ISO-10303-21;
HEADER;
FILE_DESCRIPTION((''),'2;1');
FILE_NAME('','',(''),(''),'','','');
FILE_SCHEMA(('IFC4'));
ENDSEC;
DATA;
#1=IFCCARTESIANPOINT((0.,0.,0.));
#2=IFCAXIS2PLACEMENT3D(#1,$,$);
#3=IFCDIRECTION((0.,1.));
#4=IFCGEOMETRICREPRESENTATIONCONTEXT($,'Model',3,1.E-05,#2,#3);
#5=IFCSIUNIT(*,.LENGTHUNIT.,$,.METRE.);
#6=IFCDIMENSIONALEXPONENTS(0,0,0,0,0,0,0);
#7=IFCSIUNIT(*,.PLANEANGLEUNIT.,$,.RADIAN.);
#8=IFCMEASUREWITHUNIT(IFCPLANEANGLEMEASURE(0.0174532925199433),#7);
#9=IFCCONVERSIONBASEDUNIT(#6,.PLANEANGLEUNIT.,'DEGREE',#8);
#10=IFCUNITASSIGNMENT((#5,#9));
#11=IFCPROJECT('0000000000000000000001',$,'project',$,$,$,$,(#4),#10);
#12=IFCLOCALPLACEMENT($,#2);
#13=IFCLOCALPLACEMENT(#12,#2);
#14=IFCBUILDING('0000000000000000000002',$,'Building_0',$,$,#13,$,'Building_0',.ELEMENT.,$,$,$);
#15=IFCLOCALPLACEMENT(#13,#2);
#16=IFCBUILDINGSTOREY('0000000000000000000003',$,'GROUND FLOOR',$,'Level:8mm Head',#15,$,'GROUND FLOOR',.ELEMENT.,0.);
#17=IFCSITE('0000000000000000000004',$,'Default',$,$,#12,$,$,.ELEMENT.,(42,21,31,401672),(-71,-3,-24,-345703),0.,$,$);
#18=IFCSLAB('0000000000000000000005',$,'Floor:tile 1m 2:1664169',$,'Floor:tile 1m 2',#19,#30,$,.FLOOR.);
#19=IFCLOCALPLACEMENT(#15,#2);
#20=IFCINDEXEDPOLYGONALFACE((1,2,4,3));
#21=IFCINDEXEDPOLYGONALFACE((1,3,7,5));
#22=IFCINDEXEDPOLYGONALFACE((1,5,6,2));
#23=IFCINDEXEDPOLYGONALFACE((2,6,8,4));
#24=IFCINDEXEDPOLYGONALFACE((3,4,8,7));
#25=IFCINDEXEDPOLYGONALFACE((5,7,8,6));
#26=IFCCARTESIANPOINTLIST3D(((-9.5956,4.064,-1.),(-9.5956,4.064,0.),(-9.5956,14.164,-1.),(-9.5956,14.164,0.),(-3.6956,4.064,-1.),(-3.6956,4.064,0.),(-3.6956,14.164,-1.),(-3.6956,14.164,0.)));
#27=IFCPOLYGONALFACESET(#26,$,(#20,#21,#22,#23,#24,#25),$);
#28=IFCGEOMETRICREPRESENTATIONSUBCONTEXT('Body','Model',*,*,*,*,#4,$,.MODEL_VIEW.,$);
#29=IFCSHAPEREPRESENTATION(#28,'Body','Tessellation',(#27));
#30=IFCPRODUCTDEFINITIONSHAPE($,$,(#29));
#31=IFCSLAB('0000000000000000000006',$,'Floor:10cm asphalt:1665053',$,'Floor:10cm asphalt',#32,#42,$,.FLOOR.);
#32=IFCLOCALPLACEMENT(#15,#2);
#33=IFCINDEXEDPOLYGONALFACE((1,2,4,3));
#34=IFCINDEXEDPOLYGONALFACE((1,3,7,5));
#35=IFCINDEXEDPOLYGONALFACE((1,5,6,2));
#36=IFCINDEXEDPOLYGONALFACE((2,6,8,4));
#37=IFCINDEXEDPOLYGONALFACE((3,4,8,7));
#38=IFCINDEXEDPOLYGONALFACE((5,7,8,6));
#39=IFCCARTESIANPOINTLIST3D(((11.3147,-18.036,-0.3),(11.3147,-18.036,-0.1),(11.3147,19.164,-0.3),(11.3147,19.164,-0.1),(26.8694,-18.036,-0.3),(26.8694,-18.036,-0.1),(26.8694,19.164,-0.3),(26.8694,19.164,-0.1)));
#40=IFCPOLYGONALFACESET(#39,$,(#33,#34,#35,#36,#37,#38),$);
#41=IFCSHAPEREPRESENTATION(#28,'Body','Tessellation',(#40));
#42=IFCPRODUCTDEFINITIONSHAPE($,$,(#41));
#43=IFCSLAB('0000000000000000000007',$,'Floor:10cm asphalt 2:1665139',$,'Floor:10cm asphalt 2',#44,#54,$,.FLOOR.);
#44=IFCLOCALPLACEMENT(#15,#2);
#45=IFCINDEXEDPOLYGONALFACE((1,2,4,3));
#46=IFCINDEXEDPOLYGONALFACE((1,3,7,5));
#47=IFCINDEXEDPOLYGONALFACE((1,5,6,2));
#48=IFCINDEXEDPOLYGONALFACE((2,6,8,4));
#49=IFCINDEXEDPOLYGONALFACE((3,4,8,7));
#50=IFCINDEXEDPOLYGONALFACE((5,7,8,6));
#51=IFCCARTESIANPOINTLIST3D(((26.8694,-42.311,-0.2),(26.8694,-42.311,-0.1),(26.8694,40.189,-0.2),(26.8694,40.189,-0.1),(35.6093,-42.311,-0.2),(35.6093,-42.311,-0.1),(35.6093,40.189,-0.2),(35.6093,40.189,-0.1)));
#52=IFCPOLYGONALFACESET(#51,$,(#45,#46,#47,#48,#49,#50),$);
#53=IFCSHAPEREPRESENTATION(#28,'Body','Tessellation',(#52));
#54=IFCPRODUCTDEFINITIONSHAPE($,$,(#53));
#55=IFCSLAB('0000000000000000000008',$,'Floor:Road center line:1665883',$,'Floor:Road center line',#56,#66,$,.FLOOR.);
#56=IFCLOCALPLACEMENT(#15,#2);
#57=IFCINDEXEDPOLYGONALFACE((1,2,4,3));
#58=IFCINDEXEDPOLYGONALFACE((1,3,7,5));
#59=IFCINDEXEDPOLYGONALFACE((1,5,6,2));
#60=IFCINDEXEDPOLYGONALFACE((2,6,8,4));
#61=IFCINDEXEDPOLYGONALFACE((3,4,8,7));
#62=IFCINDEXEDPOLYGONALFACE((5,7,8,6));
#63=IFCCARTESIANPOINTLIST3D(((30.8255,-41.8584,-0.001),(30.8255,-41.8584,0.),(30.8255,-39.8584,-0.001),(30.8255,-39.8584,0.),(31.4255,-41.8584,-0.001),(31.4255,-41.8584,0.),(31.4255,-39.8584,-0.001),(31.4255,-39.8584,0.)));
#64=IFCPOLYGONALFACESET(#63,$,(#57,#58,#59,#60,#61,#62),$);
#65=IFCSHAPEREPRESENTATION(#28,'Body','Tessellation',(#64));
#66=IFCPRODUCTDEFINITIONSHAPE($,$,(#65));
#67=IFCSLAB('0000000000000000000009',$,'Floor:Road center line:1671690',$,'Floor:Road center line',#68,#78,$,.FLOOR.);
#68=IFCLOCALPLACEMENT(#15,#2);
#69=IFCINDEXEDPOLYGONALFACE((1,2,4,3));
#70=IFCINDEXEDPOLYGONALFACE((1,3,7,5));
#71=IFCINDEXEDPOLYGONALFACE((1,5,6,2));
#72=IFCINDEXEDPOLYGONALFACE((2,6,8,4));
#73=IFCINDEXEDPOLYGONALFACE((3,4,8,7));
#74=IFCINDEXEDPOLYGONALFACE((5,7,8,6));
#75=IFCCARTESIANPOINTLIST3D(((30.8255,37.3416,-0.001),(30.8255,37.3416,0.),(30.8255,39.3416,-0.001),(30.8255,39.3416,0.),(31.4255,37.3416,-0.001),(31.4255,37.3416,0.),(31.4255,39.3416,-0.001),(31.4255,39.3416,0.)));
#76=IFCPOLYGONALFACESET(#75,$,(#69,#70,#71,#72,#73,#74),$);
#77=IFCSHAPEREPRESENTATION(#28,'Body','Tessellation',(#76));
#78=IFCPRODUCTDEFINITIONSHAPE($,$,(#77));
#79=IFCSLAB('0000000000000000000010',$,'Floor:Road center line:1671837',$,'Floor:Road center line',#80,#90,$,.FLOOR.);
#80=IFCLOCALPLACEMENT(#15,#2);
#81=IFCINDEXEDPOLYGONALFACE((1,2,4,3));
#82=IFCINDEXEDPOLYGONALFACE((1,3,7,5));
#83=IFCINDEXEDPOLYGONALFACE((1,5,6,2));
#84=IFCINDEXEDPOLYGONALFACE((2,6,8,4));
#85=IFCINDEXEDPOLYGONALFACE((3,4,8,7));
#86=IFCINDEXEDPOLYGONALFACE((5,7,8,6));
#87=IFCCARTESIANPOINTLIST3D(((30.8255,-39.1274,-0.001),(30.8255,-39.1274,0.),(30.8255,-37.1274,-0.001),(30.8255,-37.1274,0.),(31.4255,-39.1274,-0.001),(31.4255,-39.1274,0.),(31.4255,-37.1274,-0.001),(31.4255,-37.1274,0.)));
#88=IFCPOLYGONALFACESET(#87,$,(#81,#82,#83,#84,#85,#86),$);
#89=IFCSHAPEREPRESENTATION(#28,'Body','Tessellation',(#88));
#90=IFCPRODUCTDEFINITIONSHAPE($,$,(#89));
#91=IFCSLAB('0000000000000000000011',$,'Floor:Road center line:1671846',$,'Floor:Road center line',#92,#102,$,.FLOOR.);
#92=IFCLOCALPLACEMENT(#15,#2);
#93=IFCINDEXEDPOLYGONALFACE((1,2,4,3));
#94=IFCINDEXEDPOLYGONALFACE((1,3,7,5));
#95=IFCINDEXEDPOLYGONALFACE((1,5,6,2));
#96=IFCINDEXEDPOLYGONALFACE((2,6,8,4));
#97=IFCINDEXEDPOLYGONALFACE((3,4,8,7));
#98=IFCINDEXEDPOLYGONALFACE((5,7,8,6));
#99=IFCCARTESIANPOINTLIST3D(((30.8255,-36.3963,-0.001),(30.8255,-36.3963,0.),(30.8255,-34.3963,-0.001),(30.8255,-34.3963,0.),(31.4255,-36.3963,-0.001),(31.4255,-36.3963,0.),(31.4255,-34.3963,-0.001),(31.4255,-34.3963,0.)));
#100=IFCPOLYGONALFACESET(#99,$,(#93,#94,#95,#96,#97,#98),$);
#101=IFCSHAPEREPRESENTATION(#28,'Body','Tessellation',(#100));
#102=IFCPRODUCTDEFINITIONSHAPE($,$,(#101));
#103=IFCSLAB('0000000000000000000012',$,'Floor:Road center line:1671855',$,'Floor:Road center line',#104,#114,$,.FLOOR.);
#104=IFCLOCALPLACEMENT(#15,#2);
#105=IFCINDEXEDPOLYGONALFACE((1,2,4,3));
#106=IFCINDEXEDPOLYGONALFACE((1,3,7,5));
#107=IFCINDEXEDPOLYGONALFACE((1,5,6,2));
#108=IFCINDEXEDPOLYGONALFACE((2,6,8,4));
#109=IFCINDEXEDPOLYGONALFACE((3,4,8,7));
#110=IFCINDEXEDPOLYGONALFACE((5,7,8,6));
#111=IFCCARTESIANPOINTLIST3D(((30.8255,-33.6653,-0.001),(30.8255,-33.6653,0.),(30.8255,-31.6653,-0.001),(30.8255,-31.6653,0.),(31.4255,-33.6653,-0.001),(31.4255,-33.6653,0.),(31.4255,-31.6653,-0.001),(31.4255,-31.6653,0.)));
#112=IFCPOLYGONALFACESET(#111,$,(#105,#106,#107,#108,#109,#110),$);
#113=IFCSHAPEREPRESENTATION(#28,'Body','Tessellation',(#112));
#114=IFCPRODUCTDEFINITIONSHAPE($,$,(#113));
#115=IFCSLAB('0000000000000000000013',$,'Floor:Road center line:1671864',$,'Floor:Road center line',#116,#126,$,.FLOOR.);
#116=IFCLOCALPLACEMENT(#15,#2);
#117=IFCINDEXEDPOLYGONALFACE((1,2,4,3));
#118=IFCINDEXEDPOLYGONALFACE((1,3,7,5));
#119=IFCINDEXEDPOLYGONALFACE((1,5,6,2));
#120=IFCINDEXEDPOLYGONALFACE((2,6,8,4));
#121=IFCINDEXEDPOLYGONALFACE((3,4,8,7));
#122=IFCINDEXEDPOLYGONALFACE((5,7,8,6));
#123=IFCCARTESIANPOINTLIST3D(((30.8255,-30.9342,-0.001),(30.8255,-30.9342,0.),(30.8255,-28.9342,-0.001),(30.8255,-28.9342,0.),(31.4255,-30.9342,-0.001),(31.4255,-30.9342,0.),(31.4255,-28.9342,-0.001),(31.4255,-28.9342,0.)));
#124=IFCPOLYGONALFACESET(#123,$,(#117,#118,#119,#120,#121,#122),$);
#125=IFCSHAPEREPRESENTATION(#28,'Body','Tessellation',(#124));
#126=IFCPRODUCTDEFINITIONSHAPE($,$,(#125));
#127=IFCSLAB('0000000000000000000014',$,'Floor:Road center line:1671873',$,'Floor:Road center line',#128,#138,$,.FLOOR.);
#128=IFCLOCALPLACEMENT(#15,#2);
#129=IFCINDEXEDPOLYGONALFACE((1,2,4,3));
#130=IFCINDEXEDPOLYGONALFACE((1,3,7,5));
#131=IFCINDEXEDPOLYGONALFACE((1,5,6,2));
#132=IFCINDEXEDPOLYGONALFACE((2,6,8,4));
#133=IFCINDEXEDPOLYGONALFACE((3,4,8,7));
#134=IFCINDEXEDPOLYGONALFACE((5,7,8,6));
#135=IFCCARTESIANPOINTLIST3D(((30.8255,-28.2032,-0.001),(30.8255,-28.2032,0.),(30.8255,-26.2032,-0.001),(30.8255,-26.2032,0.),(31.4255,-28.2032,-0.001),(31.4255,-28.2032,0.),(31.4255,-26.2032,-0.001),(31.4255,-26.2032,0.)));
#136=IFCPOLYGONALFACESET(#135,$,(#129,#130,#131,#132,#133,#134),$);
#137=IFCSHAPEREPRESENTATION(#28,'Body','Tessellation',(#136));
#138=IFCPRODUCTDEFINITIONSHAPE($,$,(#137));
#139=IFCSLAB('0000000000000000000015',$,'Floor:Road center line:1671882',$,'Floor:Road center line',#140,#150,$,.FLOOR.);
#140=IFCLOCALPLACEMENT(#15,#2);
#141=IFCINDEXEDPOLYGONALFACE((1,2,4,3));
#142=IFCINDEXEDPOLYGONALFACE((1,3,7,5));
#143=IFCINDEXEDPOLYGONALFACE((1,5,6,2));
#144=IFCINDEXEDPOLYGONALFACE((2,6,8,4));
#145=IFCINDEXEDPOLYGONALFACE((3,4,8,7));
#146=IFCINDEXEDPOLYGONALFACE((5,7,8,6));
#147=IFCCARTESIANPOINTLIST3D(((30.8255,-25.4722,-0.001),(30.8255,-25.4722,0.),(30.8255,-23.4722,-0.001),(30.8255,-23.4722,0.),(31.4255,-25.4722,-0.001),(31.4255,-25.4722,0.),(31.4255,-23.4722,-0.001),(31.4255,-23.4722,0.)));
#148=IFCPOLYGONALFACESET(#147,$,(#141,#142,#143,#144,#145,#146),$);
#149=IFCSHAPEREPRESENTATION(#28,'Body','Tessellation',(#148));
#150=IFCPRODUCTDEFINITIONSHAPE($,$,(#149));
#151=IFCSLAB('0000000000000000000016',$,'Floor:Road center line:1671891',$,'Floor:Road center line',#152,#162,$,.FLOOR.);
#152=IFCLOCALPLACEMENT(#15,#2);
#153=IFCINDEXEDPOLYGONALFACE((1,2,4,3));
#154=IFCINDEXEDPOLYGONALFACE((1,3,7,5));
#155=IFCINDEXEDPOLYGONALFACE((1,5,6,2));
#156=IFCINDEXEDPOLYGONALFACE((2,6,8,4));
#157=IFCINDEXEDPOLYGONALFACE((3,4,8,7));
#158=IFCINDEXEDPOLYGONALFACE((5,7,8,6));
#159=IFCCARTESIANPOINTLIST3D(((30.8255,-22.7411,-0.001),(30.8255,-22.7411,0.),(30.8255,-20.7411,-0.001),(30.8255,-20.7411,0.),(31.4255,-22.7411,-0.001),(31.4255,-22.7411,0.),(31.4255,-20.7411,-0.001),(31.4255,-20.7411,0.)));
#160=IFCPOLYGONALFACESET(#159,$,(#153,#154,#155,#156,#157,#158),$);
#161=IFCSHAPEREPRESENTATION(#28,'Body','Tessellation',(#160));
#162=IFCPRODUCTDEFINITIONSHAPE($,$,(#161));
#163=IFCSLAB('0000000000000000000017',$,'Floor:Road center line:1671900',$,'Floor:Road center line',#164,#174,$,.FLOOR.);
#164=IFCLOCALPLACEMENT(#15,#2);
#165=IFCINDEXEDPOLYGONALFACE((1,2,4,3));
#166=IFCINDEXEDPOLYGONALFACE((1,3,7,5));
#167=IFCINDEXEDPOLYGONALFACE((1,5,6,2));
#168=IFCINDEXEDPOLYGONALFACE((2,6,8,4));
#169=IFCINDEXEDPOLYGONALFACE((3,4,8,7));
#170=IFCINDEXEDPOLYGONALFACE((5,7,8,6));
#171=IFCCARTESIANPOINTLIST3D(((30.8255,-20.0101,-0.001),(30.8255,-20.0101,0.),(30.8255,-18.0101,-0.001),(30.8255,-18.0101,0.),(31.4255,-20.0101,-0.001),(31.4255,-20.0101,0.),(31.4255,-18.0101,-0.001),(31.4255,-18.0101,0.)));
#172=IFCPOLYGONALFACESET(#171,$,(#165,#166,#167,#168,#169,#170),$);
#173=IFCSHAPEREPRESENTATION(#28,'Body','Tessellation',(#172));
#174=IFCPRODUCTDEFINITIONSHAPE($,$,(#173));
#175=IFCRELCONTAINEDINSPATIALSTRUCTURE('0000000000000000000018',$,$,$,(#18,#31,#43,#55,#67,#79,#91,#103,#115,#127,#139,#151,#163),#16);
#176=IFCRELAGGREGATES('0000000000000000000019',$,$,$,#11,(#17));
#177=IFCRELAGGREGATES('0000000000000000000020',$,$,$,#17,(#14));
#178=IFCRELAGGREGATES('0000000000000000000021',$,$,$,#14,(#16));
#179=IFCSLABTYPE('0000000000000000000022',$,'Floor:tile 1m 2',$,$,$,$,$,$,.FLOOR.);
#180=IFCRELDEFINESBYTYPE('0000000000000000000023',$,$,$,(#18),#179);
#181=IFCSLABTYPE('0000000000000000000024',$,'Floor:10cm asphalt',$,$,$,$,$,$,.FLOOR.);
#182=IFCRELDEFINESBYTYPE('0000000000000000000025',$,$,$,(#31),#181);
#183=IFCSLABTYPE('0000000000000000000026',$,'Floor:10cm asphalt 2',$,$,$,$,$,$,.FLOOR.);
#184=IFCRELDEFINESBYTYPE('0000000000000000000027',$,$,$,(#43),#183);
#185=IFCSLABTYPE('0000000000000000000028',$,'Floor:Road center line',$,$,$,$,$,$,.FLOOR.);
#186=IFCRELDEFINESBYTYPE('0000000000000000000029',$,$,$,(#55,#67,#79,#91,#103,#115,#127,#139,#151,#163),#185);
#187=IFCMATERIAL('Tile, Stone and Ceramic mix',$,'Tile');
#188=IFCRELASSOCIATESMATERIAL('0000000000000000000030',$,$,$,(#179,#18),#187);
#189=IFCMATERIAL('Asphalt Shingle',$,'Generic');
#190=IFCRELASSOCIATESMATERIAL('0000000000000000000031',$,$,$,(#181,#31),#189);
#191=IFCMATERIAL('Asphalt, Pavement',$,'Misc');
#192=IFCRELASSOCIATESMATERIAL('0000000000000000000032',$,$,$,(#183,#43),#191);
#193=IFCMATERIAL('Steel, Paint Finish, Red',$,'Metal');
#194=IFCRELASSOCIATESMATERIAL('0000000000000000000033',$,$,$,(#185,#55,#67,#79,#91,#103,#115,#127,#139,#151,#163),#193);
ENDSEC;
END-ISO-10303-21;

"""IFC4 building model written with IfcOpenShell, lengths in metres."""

from ifc_helpers import new_model, entity, si_unit, converted_unit, direction, frame, origin, place, context, subcontext, project, spatial, indexed_curve, outline, extrude, material, type_object, element, save


model = new_model("IFC4")

# Units and contexts
model_context = context("Model", 3, precision=1e-05, world=origin(), true_north=direction((0.0, 1.0)))
body_context = subcontext(model_context, "Body", "Model", "MODEL_VIEW")
ifc_project = project(units=[si_unit("LENGTHUNIT", "METRE"), converted_unit("PLANEANGLEUNIT", "DEGREE", entity("IfcPlaneAngleMeasure", 0.0174532925199433), si_unit("PLANEANGLEUNIT", "RADIAN"), dimensions=[0, 0, 0, 0, 0, 0, 0])], contexts=[model_context])

# Site, building, storey
site_placement = place(None, origin())
site = spatial("IfcSite", under=ifc_project, at=site_placement, Name="Default", CompositionType="ELEMENT", RefLatitude=(42, 21, 31, 401672), RefLongitude=(-71, -3, -24, -345703), RefElevation=0.0)
building_placement = place(site_placement, origin())
building = spatial("IfcBuilding", under=site, at=building_placement, Name="Building_0", LongName="Building_0", CompositionType="ELEMENT")
storey_placement = place(building_placement, origin())
storey = spatial("IfcBuildingStorey", under=building, at=storey_placement, Name="GROUND FLOOR", ObjectType="Level:8mm Head", LongName="GROUND FLOOR", CompositionType="ELEMENT", Elevation=0.0)

# Slabs
ifc_material_1 = material(Name="Tile, Stone and Ceramic mix", Category="Tile")
slab_type_1 = type_object("IfcSlabType", Name="Floor:tile 1m 2", PredefinedType="FLOOR", material=ifc_material_1)
slab_1_placement = place(storey_placement, origin())
element("IfcSlab", 1, at=slab_1_placement, inside=storey, type_object=slab_type_1, material=ifc_material_1, Name="Floor:tile 1m 2:1664169", ObjectType="Floor:tile 1m 2", PredefinedType="FLOOR", context=body_context, shape_type="SweptSolid", body=[
    extrude(outline(indexed_curve([(-5.05, -2.95), (5.05, -2.95), (5.05, 2.95), (-5.05, 2.95), (-5.05, -2.95)], self_intersect=False)), frame((-6.6456, 9.114, 0.0), z_axis=(0.0, 0.0, -1.0), x_axis=(0.0, 1.0, 0.0)), (0.0, 0.0, 1.0), 1.0),
])
ifc_material_2 = material(Name="Asphalt Shingle", Category="Generic")
slab_type_2 = type_object("IfcSlabType", Name="Floor:10cm asphalt", PredefinedType="FLOOR", material=ifc_material_2)
slab_2_placement = place(storey_placement, origin())
element("IfcSlab", 2, at=slab_2_placement, inside=storey, type_object=slab_type_2, material=ifc_material_2, Name="Floor:10cm asphalt:1665053", ObjectType="Floor:10cm asphalt", PredefinedType="FLOOR", context=body_context, shape_type="SweptSolid", body=[
    extrude(outline(indexed_curve([(-18.6, -7.7774), (18.6, -7.7774), (18.6, 7.7774), (-18.6, 7.7774), (-18.6, -7.7774)], self_intersect=False)), frame((19.092, 0.564, -0.1), z_axis=(0.0, 0.0, -1.0), x_axis=(0.0, 1.0, 0.0)), (0.0, 0.0, 1.0), 0.2),
])
ifc_material_3 = material(Name="Asphalt, Pavement", Category="Misc")
slab_type_3 = type_object("IfcSlabType", Name="Floor:10cm asphalt 2", PredefinedType="FLOOR", material=ifc_material_3)
slab_3_placement = place(storey_placement, origin())
element("IfcSlab", 3, at=slab_3_placement, inside=storey, type_object=slab_type_3, material=ifc_material_3, Name="Floor:10cm asphalt 2:1665139", ObjectType="Floor:10cm asphalt 2", PredefinedType="FLOOR", context=body_context, shape_type="SweptSolid", body=[
    extrude(outline(indexed_curve([(-41.25, -4.37), (41.25, -4.37), (41.25, 4.37), (-41.25, 4.37), (-41.25, -4.37)], self_intersect=False)), frame((31.2394, -1.061, -0.1), z_axis=(0.0, 0.0, -1.0), x_axis=(0.0, 1.0, 0.0)), (0.0, 0.0, 1.0), 0.1),
])
ifc_material_4 = material(Name="Steel, Paint Finish, Red", Category="Metal")
slab_type_4 = type_object("IfcSlabType", Name="Floor:Road center line", PredefinedType="FLOOR", material=ifc_material_4)
slab_4_placement = place(storey_placement, origin())
element("IfcSlab", 4, at=slab_4_placement, inside=storey, type_object=slab_type_4, material=ifc_material_4, Name="Floor:Road center line:1665883", ObjectType="Floor:Road center line", PredefinedType="FLOOR", context=body_context, shape_type="SweptSolid", body=[
    extrude(outline(indexed_curve([(-1.0, -0.3), (1.0, -0.3), (1.0, 0.3), (-1.0, 0.3), (-1.0, -0.3)], self_intersect=False)), frame((31.1255, -40.8584, 0.0), z_axis=(0.0, 0.0, -1.0), x_axis=(0.0, 1.0, 0.0)), (0.0, 0.0, 1.0), 0.001),
])
slab_5_placement = place(storey_placement, origin())
element("IfcSlab", 5, at=slab_5_placement, inside=storey, type_object=slab_type_4, material=ifc_material_4, Name="Floor:Road center line:1671690", ObjectType="Floor:Road center line", PredefinedType="FLOOR", context=body_context, shape_type="SweptSolid", body=[
    extrude(outline(indexed_curve([(-1.0, -0.3), (1.0, -0.3), (1.0, 0.3), (-1.0, 0.3), (-1.0, -0.3)], self_intersect=False)), frame((31.1255, 38.3416, 0.0), z_axis=(0.0, 0.0, -1.0), x_axis=(0.0, 1.0, 0.0)), (0.0, 0.0, 1.0), 0.001),
])
slab_6_placement = place(storey_placement, origin())
element("IfcSlab", 6, at=slab_6_placement, inside=storey, type_object=slab_type_4, material=ifc_material_4, Name="Floor:Road center line:1671837", ObjectType="Floor:Road center line", PredefinedType="FLOOR", context=body_context, shape_type="SweptSolid", body=[
    extrude(outline(indexed_curve([(-1.0, -0.3), (1.0, -0.3), (1.0, 0.3), (-1.0, 0.3), (-1.0, -0.3)], self_intersect=False)), frame((31.1255, -38.1274, 0.0), z_axis=(0.0, 0.0, -1.0), x_axis=(0.0, 1.0, 0.0)), (0.0, 0.0, 1.0), 0.001),
])
slab_7_placement = place(storey_placement, origin())
element("IfcSlab", 7, at=slab_7_placement, inside=storey, type_object=slab_type_4, material=ifc_material_4, Name="Floor:Road center line:1671846", ObjectType="Floor:Road center line", PredefinedType="FLOOR", context=body_context, shape_type="SweptSolid", body=[
    extrude(outline(indexed_curve([(-1.0, -0.3), (1.0, -0.3), (1.0, 0.3), (-1.0, 0.3), (-1.0, -0.3)], self_intersect=False)), frame((31.1255, -35.3963, 0.0), z_axis=(0.0, 0.0, -1.0), x_axis=(0.0, 1.0, 0.0)), (0.0, 0.0, 1.0), 0.001),
])
slab_8_placement = place(storey_placement, origin())
element("IfcSlab", 8, at=slab_8_placement, inside=storey, type_object=slab_type_4, material=ifc_material_4, Name="Floor:Road center line:1671855", ObjectType="Floor:Road center line", PredefinedType="FLOOR", context=body_context, shape_type="SweptSolid", body=[
    extrude(outline(indexed_curve([(-1.0, -0.3), (1.0, -0.3), (1.0, 0.3), (-1.0, 0.3), (-1.0, -0.3)], self_intersect=False)), frame((31.1255, -32.6653, 0.0), z_axis=(0.0, 0.0, -1.0), x_axis=(0.0, 1.0, 0.0)), (0.0, 0.0, 1.0), 0.001),
])
slab_9_placement = place(storey_placement, origin())
element("IfcSlab", 9, at=slab_9_placement, inside=storey, type_object=slab_type_4, material=ifc_material_4, Name="Floor:Road center line:1671864", ObjectType="Floor:Road center line", PredefinedType="FLOOR", context=body_context, shape_type="SweptSolid", body=[
    extrude(outline(indexed_curve([(-1.0, -0.3), (1.0, -0.3), (1.0, 0.3), (-1.0, 0.3), (-1.0, -0.3)], self_intersect=False)), frame((31.1255, -29.9342, 0.0), z_axis=(0.0, 0.0, -1.0), x_axis=(0.0, 1.0, 0.0)), (0.0, 0.0, 1.0), 0.001),
])
slab_10_placement = place(storey_placement, origin())
element("IfcSlab", 10, at=slab_10_placement, inside=storey, type_object=slab_type_4, material=ifc_material_4, Name="Floor:Road center line:1671873", ObjectType="Floor:Road center line", PredefinedType="FLOOR", context=body_context, shape_type="SweptSolid", body=[
    extrude(outline(indexed_curve([(-1.0, -0.3), (1.0, -0.3), (1.0, 0.3), (-1.0, 0.3), (-1.0, -0.3)], self_intersect=False)), frame((31.1255, -27.2032, 0.0), z_axis=(0.0, 0.0, -1.0), x_axis=(0.0, 1.0, 0.0)), (0.0, 0.0, 1.0), 0.001),
])
slab_11_placement = place(storey_placement, origin())
element("IfcSlab", 11, at=slab_11_placement, inside=storey, type_object=slab_type_4, material=ifc_material_4, Name="Floor:Road center line:1671882", ObjectType="Floor:Road center line", PredefinedType="FLOOR", context=body_context, shape_type="SweptSolid", body=[
    extrude(outline(indexed_curve([(-1.0, -0.3), (1.0, -0.3), (1.0, 0.3), (-1.0, 0.3), (-1.0, -0.3)], self_intersect=False)), frame((31.1255, -24.4722, 0.0), z_axis=(0.0, 0.0, -1.0), x_axis=(0.0, 1.0, 0.0)), (0.0, 0.0, 1.0), 0.001),
])
slab_12_placement = place(storey_placement, origin())
element("IfcSlab", 12, at=slab_12_placement, inside=storey, type_object=slab_type_4, material=ifc_material_4, Name="Floor:Road center line:1671891", ObjectType="Floor:Road center line", PredefinedType="FLOOR", context=body_context, shape_type="SweptSolid", body=[
    extrude(outline(indexed_curve([(-1.0, -0.3), (1.0, -0.3), (1.0, 0.3), (-1.0, 0.3), (-1.0, -0.3)], self_intersect=False)), frame((31.1255, -21.7411, 0.0), z_axis=(0.0, 0.0, -1.0), x_axis=(0.0, 1.0, 0.0)), (0.0, 0.0, 1.0), 0.001),
])
slab_13_placement = place(storey_placement, origin())
element("IfcSlab", 13, at=slab_13_placement, inside=storey, type_object=slab_type_4, material=ifc_material_4, Name="Floor:Road center line:1671900", ObjectType="Floor:Road center line", PredefinedType="FLOOR", context=body_context, shape_type="SweptSolid", body=[
    extrude(outline(indexed_curve([(-1.0, -0.3), (1.0, -0.3), (1.0, 0.3), (-1.0, 0.3), (-1.0, -0.3)], self_intersect=False)), frame((31.1255, -19.0101, 0.0), z_axis=(0.0, 0.0, -1.0), x_axis=(0.0, 1.0, 0.0)), (0.0, 0.0, 1.0), 0.001),
])

save(model, "model.ifc")
